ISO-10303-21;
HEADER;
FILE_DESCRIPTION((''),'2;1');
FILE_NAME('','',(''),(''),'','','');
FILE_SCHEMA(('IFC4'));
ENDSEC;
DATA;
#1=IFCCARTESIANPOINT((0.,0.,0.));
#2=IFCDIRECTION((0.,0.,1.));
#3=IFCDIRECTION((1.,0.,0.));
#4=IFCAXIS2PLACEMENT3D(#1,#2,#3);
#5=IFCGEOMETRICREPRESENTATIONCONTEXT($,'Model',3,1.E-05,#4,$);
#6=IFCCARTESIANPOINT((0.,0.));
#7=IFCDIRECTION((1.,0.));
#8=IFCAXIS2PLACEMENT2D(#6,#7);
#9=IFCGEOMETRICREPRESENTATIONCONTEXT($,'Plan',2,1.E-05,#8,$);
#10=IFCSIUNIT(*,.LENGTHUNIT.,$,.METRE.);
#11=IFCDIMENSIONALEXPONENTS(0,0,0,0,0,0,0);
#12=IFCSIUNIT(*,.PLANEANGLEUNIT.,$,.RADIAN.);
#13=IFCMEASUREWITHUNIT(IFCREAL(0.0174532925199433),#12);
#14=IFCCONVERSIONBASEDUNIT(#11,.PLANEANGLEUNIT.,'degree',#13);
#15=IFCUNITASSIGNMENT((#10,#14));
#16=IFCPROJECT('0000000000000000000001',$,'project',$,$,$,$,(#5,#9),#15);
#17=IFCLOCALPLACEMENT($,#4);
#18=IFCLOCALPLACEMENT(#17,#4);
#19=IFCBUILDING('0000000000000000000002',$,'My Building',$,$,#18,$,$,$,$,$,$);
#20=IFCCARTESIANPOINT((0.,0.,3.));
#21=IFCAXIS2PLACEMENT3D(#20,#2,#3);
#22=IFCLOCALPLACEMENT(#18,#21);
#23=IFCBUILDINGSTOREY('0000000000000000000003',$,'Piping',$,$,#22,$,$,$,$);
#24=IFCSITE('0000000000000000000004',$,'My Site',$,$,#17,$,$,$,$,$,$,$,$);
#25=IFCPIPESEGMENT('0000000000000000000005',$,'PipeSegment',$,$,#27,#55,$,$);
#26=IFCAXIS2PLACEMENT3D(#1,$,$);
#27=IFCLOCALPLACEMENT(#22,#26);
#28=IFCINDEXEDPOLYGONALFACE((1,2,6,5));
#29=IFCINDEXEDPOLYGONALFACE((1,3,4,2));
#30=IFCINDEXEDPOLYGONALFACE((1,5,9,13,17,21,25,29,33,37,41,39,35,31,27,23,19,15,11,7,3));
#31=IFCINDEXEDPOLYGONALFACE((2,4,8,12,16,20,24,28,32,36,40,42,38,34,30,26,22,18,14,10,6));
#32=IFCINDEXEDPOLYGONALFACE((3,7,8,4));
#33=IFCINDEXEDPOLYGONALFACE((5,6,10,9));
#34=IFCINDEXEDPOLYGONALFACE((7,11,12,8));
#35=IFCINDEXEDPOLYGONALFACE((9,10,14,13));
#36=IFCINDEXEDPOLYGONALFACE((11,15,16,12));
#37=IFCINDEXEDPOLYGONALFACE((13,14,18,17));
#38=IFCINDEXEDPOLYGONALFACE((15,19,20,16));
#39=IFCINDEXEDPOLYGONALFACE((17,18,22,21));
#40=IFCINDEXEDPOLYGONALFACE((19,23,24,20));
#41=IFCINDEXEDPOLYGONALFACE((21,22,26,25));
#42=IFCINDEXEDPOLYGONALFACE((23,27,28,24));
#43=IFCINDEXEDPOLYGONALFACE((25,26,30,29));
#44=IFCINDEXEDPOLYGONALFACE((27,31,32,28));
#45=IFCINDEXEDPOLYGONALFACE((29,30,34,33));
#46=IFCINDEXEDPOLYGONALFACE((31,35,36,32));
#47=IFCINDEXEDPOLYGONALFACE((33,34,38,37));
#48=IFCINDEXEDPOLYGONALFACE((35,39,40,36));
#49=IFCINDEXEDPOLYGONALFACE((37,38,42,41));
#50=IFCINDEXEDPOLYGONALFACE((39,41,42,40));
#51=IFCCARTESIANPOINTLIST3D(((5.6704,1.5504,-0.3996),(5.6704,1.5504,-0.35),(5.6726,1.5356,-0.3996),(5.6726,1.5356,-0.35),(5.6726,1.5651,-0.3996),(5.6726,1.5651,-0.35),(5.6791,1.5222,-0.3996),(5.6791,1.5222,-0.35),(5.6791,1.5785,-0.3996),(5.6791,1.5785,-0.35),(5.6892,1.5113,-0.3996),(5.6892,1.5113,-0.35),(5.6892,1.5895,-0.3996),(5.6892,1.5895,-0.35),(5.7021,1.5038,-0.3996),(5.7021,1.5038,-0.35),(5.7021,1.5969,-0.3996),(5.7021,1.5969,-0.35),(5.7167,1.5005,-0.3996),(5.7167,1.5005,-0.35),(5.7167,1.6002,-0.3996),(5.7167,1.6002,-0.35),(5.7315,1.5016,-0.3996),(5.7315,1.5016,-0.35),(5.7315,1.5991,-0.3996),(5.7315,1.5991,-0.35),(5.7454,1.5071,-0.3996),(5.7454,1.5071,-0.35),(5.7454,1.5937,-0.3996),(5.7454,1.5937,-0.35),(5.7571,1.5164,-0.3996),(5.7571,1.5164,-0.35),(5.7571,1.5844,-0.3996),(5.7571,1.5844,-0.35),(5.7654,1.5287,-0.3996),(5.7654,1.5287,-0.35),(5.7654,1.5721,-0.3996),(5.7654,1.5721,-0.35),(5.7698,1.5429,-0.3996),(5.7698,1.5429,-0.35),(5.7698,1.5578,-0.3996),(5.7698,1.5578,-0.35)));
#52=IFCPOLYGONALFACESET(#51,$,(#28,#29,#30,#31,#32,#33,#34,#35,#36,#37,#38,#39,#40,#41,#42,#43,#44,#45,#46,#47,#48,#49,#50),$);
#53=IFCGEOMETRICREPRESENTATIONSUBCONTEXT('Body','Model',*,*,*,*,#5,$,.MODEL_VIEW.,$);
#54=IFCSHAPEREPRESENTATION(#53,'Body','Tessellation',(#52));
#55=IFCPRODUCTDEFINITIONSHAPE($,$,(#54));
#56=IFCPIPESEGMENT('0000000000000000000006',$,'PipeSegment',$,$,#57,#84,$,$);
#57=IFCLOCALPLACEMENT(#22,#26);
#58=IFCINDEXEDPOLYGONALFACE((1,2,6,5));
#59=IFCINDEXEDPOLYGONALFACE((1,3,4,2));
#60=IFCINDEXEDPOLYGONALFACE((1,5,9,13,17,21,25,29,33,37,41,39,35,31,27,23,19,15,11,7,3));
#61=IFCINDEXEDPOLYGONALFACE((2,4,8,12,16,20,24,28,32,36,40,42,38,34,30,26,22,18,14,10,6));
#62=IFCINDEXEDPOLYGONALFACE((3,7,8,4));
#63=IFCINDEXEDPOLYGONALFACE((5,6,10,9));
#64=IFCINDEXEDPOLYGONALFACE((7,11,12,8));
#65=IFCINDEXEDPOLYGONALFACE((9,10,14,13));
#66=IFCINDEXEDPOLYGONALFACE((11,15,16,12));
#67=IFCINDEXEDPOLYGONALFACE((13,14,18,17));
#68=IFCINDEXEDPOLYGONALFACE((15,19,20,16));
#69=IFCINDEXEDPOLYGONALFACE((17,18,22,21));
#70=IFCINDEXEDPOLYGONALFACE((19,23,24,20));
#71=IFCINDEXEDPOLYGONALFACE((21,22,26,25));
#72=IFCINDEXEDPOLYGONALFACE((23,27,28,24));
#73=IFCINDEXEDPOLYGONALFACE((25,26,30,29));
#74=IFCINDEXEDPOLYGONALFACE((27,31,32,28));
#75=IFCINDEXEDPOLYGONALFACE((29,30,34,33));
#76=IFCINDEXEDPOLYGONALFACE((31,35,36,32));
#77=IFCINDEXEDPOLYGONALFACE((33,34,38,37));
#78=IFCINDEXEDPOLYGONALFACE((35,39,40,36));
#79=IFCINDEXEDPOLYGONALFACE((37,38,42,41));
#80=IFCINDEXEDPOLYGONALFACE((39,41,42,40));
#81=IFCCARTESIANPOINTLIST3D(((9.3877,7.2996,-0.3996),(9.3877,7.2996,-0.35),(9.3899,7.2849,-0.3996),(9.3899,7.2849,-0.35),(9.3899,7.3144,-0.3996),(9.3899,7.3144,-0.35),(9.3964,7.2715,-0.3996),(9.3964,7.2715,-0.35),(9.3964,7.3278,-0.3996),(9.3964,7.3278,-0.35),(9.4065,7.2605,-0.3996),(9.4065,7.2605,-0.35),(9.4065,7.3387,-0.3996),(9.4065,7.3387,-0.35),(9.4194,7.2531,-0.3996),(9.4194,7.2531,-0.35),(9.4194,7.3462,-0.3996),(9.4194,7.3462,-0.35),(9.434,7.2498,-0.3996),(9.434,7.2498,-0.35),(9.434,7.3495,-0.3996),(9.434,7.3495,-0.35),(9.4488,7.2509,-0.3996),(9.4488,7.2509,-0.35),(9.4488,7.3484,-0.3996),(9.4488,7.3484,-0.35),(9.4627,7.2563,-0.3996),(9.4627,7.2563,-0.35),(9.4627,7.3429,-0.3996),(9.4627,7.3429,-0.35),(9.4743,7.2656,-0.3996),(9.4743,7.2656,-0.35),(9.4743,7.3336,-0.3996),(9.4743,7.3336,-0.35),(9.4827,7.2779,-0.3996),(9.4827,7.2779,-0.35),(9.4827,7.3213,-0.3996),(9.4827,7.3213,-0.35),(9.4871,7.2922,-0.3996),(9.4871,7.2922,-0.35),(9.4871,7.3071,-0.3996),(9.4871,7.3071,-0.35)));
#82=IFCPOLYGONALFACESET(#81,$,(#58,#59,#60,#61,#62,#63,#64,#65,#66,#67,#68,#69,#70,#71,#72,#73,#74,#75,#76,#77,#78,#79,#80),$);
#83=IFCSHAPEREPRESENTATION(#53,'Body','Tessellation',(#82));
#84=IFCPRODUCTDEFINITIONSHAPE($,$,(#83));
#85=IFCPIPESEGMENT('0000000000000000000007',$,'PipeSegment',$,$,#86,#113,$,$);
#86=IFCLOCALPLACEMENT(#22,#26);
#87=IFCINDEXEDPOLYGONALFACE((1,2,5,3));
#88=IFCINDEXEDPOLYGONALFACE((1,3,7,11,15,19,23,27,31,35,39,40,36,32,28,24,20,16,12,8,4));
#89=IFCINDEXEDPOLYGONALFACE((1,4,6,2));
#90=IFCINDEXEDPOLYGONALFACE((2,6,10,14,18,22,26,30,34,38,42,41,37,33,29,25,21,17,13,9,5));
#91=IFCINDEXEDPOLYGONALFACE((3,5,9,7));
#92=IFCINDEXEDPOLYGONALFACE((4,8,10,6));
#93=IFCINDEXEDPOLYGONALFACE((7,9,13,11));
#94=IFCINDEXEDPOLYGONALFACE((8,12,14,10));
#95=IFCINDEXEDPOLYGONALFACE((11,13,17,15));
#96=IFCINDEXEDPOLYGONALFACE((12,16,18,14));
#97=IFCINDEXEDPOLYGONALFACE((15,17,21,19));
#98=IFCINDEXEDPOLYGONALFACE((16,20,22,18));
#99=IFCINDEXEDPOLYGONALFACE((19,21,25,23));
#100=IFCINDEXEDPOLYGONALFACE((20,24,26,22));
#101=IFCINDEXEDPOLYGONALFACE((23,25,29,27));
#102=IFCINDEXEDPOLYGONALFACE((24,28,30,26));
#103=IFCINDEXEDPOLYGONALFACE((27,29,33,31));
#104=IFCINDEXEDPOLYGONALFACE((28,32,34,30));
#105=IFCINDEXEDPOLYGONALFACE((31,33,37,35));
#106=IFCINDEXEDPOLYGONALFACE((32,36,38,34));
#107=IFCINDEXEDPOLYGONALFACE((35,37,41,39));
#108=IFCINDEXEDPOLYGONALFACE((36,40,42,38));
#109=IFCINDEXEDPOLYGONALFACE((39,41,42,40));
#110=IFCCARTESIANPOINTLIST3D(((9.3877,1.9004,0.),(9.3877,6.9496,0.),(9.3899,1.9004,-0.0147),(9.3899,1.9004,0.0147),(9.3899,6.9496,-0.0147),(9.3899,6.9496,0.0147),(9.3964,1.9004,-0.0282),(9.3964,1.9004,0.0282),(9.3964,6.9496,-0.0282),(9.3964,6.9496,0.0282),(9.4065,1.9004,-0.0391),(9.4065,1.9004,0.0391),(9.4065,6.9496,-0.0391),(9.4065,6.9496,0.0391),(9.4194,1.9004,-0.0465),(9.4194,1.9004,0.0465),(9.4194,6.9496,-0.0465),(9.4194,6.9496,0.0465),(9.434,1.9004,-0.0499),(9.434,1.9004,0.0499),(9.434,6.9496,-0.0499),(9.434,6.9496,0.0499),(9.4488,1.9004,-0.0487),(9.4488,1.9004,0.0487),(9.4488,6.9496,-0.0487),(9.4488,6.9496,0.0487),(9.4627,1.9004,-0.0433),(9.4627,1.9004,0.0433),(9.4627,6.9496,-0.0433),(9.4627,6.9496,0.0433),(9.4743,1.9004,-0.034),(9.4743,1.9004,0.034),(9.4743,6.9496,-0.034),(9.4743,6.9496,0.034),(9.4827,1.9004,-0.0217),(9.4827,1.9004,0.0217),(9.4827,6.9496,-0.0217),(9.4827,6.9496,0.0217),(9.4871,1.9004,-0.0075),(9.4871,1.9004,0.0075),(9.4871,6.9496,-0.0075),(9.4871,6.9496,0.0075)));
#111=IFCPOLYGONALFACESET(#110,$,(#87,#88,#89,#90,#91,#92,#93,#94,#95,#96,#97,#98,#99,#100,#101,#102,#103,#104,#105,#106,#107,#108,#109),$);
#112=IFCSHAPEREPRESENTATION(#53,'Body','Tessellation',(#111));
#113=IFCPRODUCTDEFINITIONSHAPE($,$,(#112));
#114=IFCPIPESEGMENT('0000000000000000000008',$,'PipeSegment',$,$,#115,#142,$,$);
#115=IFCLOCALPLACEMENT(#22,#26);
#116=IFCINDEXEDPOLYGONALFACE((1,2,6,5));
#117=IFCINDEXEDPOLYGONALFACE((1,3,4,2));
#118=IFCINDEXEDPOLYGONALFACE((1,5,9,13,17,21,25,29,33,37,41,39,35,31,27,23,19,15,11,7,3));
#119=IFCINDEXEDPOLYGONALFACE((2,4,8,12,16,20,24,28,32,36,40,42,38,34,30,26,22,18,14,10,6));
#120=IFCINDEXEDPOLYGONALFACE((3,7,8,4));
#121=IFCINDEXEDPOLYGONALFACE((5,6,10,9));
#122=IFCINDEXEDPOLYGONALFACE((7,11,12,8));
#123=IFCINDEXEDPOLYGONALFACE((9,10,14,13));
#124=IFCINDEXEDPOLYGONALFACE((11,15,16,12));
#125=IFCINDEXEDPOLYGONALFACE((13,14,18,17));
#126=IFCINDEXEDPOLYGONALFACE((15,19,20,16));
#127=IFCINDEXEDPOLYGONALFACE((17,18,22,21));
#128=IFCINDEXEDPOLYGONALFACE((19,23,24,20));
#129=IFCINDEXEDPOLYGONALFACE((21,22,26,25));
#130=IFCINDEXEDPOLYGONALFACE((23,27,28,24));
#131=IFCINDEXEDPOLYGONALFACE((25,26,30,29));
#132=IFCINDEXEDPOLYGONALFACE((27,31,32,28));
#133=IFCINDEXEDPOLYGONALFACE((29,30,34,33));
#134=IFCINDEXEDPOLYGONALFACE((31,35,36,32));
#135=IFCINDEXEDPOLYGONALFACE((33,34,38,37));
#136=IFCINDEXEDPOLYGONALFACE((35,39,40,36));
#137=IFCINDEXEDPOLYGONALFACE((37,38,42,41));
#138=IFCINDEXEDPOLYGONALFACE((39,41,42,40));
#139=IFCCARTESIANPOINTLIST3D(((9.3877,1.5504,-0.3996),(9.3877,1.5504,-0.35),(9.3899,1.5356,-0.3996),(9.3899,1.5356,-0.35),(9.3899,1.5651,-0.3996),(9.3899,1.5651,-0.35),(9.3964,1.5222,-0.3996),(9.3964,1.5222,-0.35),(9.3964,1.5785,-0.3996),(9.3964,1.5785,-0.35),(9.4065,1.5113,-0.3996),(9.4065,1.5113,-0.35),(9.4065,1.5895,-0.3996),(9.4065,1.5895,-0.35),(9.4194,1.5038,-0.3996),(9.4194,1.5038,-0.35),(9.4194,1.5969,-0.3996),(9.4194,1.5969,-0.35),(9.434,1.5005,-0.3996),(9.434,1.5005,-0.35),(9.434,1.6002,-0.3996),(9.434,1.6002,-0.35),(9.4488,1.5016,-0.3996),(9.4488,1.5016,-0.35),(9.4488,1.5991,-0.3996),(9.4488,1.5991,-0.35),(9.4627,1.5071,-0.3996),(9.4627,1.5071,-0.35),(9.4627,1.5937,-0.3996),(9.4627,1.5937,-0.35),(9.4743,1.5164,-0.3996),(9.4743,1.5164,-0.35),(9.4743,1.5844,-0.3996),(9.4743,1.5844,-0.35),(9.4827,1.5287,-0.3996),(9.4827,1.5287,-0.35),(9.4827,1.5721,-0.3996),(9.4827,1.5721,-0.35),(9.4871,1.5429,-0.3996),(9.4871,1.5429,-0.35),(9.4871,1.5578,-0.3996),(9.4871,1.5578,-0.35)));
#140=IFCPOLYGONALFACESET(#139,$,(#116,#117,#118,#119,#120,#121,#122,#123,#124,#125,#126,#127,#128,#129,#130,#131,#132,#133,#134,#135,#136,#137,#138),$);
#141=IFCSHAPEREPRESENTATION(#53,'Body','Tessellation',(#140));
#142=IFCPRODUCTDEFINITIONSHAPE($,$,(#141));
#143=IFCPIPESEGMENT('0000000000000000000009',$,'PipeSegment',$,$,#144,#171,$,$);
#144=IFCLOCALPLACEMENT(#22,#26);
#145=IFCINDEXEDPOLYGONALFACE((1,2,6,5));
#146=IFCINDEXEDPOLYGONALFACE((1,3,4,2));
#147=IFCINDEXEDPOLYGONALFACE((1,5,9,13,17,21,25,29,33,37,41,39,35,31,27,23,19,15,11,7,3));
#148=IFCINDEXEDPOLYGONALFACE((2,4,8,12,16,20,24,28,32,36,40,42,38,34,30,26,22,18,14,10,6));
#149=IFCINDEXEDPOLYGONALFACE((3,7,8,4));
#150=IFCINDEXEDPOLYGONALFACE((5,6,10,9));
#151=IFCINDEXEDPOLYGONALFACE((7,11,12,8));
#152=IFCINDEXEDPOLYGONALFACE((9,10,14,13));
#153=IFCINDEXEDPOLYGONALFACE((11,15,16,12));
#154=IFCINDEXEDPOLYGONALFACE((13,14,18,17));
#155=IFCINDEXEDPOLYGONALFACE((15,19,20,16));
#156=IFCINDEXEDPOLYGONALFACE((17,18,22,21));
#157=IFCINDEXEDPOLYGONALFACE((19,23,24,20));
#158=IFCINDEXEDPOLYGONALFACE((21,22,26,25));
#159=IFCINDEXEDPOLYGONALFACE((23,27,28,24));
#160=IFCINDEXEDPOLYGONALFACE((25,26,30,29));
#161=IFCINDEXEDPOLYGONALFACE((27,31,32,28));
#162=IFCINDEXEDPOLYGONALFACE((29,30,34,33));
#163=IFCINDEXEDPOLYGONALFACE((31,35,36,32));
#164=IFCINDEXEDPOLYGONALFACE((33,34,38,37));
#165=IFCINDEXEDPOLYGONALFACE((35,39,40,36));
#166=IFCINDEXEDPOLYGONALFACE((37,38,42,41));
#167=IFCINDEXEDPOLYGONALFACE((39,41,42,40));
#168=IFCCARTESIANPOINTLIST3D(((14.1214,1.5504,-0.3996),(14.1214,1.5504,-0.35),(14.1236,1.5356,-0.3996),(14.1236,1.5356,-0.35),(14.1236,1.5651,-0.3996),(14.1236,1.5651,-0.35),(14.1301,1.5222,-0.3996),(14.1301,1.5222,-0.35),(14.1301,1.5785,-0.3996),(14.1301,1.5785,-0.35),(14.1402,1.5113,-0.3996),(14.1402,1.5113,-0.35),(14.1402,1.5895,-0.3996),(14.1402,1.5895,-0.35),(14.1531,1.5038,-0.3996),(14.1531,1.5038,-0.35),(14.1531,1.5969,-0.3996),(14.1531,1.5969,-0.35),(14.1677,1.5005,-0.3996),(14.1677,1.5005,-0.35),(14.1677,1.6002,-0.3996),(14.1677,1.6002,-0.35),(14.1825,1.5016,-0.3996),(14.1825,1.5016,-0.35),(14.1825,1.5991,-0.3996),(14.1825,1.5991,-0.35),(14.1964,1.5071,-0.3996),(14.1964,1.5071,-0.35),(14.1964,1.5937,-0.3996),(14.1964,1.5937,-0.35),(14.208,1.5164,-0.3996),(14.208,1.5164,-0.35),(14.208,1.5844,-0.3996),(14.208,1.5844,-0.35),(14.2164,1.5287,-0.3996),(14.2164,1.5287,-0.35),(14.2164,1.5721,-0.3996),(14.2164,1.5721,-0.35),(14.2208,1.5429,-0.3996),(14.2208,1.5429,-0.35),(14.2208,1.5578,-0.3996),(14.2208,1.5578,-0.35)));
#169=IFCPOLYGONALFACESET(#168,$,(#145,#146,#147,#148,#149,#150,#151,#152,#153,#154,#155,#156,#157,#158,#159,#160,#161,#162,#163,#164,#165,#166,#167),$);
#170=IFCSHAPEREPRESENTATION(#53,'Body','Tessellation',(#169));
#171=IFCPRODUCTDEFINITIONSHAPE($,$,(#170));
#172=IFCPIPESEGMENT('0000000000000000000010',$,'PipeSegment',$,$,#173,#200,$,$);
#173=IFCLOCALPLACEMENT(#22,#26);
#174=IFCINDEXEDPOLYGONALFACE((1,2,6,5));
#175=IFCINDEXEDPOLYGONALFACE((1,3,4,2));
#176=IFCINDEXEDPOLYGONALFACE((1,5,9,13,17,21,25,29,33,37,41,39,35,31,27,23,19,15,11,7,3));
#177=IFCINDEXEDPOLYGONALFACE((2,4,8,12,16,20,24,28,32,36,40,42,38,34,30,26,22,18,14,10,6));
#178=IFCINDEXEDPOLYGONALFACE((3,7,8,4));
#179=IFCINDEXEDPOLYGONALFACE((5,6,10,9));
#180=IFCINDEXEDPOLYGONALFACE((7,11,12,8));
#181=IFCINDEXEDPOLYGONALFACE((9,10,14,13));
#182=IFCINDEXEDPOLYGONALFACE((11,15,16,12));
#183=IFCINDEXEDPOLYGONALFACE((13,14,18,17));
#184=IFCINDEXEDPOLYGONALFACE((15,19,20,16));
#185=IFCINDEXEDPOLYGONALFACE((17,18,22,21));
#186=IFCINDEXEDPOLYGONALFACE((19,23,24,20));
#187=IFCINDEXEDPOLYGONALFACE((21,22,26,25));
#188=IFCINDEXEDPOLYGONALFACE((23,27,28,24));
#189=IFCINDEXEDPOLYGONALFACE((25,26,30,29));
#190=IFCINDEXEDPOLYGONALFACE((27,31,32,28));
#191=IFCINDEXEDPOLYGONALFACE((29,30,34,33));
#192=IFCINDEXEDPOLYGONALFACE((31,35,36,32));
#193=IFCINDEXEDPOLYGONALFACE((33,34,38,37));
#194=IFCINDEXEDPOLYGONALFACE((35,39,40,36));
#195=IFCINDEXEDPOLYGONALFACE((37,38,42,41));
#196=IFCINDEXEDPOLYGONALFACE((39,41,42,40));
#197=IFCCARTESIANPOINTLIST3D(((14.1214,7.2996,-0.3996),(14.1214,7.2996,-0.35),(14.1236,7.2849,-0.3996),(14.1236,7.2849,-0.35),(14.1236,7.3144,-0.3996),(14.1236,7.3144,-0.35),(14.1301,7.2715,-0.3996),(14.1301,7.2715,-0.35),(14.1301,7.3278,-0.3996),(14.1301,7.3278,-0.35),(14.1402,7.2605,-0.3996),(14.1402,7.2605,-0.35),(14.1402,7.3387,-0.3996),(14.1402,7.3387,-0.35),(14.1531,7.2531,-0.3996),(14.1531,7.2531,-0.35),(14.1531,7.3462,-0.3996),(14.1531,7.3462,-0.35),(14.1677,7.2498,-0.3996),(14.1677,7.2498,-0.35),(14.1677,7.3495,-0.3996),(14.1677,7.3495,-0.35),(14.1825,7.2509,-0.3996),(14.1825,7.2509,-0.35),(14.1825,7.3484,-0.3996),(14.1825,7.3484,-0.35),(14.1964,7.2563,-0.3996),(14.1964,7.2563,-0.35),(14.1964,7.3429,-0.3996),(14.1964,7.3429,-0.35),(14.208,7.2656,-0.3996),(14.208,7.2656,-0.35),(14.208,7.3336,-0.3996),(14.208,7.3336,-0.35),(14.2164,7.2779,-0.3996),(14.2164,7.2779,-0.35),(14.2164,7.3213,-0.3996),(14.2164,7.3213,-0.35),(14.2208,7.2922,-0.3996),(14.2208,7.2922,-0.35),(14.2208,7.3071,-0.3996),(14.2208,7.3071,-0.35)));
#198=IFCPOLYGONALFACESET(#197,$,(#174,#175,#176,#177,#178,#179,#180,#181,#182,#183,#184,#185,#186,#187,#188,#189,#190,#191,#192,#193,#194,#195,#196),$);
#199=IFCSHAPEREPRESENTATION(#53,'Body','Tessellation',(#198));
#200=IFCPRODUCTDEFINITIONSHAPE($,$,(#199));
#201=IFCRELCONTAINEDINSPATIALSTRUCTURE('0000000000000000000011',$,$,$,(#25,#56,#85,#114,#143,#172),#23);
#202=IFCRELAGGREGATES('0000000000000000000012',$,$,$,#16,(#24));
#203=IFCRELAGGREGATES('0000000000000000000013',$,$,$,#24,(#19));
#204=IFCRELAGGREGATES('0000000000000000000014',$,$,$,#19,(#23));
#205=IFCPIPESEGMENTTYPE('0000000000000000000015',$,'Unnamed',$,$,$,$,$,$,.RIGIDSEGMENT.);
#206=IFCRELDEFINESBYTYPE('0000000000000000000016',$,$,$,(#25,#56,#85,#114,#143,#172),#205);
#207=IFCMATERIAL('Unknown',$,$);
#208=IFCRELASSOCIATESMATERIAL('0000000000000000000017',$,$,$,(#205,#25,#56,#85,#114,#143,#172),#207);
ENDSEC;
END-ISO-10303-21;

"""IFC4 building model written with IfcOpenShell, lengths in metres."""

from ifc_helpers import new_model, entity, si_unit, converted_unit, frame, origin_with_axes, origin_2d_with_axis, place, context, subcontext, project, spatial, circle, extrude, material, material_profile, profile_set, profile_usage, type_object, element, save


model = new_model("IFC4")

# Units and contexts
model_context = context("Model", 3, precision=1e-05, world=origin_with_axes())
plan_context = context("Plan", 2, precision=1e-05, world=origin_2d_with_axis())
body_context = subcontext(model_context, "Body", "Model", "MODEL_VIEW")
ifc_project = project(units=[si_unit("LENGTHUNIT", "METRE"), converted_unit("PLANEANGLEUNIT", "degree", entity("IfcReal", 0.0174532925199433), si_unit("PLANEANGLEUNIT", "RADIAN"), dimensions=[0, 0, 0, 0, 0, 0, 0])], contexts=[model_context, plan_context])

# Site, building, storey
site_placement = place(None, origin_with_axes())
site = spatial("IfcSite", under=ifc_project, at=site_placement, Name="My Site")
building_placement = place(site_placement, origin_with_axes())
building = spatial("IfcBuilding", under=site, at=building_placement, Name="My Building")
storey_placement = place(building_placement, frame((0.0, 0.0, 3.0), z_axis=(0.0, 0.0, 1.0), x_axis=(1.0, 0.0, 0.0)))
storey = spatial("IfcBuildingStorey", under=building, at=storey_placement, Name="Piping")

# Pipe segments
ifc_material = material(Name="Unknown")
ifc_material_profile = material_profile(ifc_material, circle(Radius=0.05))
ifc_profile_set = profile_set([ifc_material_profile])
pipe_segment_type = type_object("IfcPipeSegmentType", Name="Unnamed", PredefinedType="RIGIDSEGMENT", material=ifc_profile_set)
ifc_profile_usage_1 = profile_usage(ifc_profile_set, cardinal=5)
pipe_segment_1_placement = place(storey_placement, frame((5.7204, 1.5504, -0.35), z_axis=(0.0, 0.0, -1.0), x_axis=(-1.0, 0.0, 0.0)))
element("IfcPipeSegment", 1, at=pipe_segment_1_placement, inside=storey, type_object=pipe_segment_type, material=ifc_profile_usage_1, Name="PipeSegment", context=body_context, shape_type="SweptSolid", body=[
    extrude(circle(Radius=0.05), origin_with_axes(), (0.0, 0.0, 1.0), 0.0496),
])
ifc_profile_usage_2 = profile_usage(ifc_profile_set, cardinal=5)
pipe_segment_2_placement = place(storey_placement, frame((9.4377, 7.2996, -0.35), z_axis=(0.0, 0.0, -1.0), x_axis=(-1.0, 0.0, 0.0)))
element("IfcPipeSegment", 2, at=pipe_segment_2_placement, inside=storey, type_object=pipe_segment_type, material=ifc_profile_usage_2, Name="PipeSegment", context=body_context, shape_type="SweptSolid", body=[
    extrude(circle(Radius=0.05), origin_with_axes(), (0.0, 0.0, 1.0), 0.0496),
])
ifc_profile_usage_3 = profile_usage(ifc_profile_set, cardinal=5)
pipe_segment_3_placement = place(storey_placement, frame((9.4377, 1.9004, 0.0), z_axis=(0.0, 1.0, 0.0), x_axis=(-1.0, 0.0, 0.0)))
element("IfcPipeSegment", 3, at=pipe_segment_3_placement, inside=storey, type_object=pipe_segment_type, material=ifc_profile_usage_3, Name="PipeSegment", context=body_context, shape_type="SweptSolid", body=[
    extrude(circle(Radius=0.05), origin_with_axes(), (0.0, 0.0, 1.0), 5.0493),
])
ifc_profile_usage_4 = profile_usage(ifc_profile_set, cardinal=5)
pipe_segment_4_placement = place(storey_placement, frame((9.4377, 1.5504, -0.35), z_axis=(0.0, 0.0, -1.0), x_axis=(-1.0, 0.0, 0.0)))
element("IfcPipeSegment", 4, at=pipe_segment_4_placement, inside=storey, type_object=pipe_segment_type, material=ifc_profile_usage_4, Name="PipeSegment", context=body_context, shape_type="SweptSolid", body=[
    extrude(circle(Radius=0.05), origin_with_axes(), (0.0, 0.0, 1.0), 0.0496),
])
ifc_profile_usage_5 = profile_usage(ifc_profile_set, cardinal=5)
pipe_segment_5_placement = place(storey_placement, frame((14.1714, 1.5504, -0.35), z_axis=(0.0, 0.0, -1.0), x_axis=(-1.0, 0.0, 0.0)))
element("IfcPipeSegment", 5, at=pipe_segment_5_placement, inside=storey, type_object=pipe_segment_type, material=ifc_profile_usage_5, Name="PipeSegment", context=body_context, shape_type="SweptSolid", body=[
    extrude(circle(Radius=0.05), origin_with_axes(), (0.0, 0.0, 1.0), 0.0496),
])
ifc_profile_usage_6 = profile_usage(ifc_profile_set, cardinal=5)
pipe_segment_6_placement = place(storey_placement, frame((14.1714, 7.2996, -0.35), z_axis=(0.0, 0.0, -1.0), x_axis=(-1.0, 0.0, 0.0)))
element("IfcPipeSegment", 6, at=pipe_segment_6_placement, inside=storey, type_object=pipe_segment_type, material=ifc_profile_usage_6, Name="PipeSegment", context=body_context, shape_type="SweptSolid", body=[
    extrude(circle(Radius=0.05), origin_with_axes(), (0.0, 0.0, 1.0), 0.0496),
])

save(model, "model.ifc")
